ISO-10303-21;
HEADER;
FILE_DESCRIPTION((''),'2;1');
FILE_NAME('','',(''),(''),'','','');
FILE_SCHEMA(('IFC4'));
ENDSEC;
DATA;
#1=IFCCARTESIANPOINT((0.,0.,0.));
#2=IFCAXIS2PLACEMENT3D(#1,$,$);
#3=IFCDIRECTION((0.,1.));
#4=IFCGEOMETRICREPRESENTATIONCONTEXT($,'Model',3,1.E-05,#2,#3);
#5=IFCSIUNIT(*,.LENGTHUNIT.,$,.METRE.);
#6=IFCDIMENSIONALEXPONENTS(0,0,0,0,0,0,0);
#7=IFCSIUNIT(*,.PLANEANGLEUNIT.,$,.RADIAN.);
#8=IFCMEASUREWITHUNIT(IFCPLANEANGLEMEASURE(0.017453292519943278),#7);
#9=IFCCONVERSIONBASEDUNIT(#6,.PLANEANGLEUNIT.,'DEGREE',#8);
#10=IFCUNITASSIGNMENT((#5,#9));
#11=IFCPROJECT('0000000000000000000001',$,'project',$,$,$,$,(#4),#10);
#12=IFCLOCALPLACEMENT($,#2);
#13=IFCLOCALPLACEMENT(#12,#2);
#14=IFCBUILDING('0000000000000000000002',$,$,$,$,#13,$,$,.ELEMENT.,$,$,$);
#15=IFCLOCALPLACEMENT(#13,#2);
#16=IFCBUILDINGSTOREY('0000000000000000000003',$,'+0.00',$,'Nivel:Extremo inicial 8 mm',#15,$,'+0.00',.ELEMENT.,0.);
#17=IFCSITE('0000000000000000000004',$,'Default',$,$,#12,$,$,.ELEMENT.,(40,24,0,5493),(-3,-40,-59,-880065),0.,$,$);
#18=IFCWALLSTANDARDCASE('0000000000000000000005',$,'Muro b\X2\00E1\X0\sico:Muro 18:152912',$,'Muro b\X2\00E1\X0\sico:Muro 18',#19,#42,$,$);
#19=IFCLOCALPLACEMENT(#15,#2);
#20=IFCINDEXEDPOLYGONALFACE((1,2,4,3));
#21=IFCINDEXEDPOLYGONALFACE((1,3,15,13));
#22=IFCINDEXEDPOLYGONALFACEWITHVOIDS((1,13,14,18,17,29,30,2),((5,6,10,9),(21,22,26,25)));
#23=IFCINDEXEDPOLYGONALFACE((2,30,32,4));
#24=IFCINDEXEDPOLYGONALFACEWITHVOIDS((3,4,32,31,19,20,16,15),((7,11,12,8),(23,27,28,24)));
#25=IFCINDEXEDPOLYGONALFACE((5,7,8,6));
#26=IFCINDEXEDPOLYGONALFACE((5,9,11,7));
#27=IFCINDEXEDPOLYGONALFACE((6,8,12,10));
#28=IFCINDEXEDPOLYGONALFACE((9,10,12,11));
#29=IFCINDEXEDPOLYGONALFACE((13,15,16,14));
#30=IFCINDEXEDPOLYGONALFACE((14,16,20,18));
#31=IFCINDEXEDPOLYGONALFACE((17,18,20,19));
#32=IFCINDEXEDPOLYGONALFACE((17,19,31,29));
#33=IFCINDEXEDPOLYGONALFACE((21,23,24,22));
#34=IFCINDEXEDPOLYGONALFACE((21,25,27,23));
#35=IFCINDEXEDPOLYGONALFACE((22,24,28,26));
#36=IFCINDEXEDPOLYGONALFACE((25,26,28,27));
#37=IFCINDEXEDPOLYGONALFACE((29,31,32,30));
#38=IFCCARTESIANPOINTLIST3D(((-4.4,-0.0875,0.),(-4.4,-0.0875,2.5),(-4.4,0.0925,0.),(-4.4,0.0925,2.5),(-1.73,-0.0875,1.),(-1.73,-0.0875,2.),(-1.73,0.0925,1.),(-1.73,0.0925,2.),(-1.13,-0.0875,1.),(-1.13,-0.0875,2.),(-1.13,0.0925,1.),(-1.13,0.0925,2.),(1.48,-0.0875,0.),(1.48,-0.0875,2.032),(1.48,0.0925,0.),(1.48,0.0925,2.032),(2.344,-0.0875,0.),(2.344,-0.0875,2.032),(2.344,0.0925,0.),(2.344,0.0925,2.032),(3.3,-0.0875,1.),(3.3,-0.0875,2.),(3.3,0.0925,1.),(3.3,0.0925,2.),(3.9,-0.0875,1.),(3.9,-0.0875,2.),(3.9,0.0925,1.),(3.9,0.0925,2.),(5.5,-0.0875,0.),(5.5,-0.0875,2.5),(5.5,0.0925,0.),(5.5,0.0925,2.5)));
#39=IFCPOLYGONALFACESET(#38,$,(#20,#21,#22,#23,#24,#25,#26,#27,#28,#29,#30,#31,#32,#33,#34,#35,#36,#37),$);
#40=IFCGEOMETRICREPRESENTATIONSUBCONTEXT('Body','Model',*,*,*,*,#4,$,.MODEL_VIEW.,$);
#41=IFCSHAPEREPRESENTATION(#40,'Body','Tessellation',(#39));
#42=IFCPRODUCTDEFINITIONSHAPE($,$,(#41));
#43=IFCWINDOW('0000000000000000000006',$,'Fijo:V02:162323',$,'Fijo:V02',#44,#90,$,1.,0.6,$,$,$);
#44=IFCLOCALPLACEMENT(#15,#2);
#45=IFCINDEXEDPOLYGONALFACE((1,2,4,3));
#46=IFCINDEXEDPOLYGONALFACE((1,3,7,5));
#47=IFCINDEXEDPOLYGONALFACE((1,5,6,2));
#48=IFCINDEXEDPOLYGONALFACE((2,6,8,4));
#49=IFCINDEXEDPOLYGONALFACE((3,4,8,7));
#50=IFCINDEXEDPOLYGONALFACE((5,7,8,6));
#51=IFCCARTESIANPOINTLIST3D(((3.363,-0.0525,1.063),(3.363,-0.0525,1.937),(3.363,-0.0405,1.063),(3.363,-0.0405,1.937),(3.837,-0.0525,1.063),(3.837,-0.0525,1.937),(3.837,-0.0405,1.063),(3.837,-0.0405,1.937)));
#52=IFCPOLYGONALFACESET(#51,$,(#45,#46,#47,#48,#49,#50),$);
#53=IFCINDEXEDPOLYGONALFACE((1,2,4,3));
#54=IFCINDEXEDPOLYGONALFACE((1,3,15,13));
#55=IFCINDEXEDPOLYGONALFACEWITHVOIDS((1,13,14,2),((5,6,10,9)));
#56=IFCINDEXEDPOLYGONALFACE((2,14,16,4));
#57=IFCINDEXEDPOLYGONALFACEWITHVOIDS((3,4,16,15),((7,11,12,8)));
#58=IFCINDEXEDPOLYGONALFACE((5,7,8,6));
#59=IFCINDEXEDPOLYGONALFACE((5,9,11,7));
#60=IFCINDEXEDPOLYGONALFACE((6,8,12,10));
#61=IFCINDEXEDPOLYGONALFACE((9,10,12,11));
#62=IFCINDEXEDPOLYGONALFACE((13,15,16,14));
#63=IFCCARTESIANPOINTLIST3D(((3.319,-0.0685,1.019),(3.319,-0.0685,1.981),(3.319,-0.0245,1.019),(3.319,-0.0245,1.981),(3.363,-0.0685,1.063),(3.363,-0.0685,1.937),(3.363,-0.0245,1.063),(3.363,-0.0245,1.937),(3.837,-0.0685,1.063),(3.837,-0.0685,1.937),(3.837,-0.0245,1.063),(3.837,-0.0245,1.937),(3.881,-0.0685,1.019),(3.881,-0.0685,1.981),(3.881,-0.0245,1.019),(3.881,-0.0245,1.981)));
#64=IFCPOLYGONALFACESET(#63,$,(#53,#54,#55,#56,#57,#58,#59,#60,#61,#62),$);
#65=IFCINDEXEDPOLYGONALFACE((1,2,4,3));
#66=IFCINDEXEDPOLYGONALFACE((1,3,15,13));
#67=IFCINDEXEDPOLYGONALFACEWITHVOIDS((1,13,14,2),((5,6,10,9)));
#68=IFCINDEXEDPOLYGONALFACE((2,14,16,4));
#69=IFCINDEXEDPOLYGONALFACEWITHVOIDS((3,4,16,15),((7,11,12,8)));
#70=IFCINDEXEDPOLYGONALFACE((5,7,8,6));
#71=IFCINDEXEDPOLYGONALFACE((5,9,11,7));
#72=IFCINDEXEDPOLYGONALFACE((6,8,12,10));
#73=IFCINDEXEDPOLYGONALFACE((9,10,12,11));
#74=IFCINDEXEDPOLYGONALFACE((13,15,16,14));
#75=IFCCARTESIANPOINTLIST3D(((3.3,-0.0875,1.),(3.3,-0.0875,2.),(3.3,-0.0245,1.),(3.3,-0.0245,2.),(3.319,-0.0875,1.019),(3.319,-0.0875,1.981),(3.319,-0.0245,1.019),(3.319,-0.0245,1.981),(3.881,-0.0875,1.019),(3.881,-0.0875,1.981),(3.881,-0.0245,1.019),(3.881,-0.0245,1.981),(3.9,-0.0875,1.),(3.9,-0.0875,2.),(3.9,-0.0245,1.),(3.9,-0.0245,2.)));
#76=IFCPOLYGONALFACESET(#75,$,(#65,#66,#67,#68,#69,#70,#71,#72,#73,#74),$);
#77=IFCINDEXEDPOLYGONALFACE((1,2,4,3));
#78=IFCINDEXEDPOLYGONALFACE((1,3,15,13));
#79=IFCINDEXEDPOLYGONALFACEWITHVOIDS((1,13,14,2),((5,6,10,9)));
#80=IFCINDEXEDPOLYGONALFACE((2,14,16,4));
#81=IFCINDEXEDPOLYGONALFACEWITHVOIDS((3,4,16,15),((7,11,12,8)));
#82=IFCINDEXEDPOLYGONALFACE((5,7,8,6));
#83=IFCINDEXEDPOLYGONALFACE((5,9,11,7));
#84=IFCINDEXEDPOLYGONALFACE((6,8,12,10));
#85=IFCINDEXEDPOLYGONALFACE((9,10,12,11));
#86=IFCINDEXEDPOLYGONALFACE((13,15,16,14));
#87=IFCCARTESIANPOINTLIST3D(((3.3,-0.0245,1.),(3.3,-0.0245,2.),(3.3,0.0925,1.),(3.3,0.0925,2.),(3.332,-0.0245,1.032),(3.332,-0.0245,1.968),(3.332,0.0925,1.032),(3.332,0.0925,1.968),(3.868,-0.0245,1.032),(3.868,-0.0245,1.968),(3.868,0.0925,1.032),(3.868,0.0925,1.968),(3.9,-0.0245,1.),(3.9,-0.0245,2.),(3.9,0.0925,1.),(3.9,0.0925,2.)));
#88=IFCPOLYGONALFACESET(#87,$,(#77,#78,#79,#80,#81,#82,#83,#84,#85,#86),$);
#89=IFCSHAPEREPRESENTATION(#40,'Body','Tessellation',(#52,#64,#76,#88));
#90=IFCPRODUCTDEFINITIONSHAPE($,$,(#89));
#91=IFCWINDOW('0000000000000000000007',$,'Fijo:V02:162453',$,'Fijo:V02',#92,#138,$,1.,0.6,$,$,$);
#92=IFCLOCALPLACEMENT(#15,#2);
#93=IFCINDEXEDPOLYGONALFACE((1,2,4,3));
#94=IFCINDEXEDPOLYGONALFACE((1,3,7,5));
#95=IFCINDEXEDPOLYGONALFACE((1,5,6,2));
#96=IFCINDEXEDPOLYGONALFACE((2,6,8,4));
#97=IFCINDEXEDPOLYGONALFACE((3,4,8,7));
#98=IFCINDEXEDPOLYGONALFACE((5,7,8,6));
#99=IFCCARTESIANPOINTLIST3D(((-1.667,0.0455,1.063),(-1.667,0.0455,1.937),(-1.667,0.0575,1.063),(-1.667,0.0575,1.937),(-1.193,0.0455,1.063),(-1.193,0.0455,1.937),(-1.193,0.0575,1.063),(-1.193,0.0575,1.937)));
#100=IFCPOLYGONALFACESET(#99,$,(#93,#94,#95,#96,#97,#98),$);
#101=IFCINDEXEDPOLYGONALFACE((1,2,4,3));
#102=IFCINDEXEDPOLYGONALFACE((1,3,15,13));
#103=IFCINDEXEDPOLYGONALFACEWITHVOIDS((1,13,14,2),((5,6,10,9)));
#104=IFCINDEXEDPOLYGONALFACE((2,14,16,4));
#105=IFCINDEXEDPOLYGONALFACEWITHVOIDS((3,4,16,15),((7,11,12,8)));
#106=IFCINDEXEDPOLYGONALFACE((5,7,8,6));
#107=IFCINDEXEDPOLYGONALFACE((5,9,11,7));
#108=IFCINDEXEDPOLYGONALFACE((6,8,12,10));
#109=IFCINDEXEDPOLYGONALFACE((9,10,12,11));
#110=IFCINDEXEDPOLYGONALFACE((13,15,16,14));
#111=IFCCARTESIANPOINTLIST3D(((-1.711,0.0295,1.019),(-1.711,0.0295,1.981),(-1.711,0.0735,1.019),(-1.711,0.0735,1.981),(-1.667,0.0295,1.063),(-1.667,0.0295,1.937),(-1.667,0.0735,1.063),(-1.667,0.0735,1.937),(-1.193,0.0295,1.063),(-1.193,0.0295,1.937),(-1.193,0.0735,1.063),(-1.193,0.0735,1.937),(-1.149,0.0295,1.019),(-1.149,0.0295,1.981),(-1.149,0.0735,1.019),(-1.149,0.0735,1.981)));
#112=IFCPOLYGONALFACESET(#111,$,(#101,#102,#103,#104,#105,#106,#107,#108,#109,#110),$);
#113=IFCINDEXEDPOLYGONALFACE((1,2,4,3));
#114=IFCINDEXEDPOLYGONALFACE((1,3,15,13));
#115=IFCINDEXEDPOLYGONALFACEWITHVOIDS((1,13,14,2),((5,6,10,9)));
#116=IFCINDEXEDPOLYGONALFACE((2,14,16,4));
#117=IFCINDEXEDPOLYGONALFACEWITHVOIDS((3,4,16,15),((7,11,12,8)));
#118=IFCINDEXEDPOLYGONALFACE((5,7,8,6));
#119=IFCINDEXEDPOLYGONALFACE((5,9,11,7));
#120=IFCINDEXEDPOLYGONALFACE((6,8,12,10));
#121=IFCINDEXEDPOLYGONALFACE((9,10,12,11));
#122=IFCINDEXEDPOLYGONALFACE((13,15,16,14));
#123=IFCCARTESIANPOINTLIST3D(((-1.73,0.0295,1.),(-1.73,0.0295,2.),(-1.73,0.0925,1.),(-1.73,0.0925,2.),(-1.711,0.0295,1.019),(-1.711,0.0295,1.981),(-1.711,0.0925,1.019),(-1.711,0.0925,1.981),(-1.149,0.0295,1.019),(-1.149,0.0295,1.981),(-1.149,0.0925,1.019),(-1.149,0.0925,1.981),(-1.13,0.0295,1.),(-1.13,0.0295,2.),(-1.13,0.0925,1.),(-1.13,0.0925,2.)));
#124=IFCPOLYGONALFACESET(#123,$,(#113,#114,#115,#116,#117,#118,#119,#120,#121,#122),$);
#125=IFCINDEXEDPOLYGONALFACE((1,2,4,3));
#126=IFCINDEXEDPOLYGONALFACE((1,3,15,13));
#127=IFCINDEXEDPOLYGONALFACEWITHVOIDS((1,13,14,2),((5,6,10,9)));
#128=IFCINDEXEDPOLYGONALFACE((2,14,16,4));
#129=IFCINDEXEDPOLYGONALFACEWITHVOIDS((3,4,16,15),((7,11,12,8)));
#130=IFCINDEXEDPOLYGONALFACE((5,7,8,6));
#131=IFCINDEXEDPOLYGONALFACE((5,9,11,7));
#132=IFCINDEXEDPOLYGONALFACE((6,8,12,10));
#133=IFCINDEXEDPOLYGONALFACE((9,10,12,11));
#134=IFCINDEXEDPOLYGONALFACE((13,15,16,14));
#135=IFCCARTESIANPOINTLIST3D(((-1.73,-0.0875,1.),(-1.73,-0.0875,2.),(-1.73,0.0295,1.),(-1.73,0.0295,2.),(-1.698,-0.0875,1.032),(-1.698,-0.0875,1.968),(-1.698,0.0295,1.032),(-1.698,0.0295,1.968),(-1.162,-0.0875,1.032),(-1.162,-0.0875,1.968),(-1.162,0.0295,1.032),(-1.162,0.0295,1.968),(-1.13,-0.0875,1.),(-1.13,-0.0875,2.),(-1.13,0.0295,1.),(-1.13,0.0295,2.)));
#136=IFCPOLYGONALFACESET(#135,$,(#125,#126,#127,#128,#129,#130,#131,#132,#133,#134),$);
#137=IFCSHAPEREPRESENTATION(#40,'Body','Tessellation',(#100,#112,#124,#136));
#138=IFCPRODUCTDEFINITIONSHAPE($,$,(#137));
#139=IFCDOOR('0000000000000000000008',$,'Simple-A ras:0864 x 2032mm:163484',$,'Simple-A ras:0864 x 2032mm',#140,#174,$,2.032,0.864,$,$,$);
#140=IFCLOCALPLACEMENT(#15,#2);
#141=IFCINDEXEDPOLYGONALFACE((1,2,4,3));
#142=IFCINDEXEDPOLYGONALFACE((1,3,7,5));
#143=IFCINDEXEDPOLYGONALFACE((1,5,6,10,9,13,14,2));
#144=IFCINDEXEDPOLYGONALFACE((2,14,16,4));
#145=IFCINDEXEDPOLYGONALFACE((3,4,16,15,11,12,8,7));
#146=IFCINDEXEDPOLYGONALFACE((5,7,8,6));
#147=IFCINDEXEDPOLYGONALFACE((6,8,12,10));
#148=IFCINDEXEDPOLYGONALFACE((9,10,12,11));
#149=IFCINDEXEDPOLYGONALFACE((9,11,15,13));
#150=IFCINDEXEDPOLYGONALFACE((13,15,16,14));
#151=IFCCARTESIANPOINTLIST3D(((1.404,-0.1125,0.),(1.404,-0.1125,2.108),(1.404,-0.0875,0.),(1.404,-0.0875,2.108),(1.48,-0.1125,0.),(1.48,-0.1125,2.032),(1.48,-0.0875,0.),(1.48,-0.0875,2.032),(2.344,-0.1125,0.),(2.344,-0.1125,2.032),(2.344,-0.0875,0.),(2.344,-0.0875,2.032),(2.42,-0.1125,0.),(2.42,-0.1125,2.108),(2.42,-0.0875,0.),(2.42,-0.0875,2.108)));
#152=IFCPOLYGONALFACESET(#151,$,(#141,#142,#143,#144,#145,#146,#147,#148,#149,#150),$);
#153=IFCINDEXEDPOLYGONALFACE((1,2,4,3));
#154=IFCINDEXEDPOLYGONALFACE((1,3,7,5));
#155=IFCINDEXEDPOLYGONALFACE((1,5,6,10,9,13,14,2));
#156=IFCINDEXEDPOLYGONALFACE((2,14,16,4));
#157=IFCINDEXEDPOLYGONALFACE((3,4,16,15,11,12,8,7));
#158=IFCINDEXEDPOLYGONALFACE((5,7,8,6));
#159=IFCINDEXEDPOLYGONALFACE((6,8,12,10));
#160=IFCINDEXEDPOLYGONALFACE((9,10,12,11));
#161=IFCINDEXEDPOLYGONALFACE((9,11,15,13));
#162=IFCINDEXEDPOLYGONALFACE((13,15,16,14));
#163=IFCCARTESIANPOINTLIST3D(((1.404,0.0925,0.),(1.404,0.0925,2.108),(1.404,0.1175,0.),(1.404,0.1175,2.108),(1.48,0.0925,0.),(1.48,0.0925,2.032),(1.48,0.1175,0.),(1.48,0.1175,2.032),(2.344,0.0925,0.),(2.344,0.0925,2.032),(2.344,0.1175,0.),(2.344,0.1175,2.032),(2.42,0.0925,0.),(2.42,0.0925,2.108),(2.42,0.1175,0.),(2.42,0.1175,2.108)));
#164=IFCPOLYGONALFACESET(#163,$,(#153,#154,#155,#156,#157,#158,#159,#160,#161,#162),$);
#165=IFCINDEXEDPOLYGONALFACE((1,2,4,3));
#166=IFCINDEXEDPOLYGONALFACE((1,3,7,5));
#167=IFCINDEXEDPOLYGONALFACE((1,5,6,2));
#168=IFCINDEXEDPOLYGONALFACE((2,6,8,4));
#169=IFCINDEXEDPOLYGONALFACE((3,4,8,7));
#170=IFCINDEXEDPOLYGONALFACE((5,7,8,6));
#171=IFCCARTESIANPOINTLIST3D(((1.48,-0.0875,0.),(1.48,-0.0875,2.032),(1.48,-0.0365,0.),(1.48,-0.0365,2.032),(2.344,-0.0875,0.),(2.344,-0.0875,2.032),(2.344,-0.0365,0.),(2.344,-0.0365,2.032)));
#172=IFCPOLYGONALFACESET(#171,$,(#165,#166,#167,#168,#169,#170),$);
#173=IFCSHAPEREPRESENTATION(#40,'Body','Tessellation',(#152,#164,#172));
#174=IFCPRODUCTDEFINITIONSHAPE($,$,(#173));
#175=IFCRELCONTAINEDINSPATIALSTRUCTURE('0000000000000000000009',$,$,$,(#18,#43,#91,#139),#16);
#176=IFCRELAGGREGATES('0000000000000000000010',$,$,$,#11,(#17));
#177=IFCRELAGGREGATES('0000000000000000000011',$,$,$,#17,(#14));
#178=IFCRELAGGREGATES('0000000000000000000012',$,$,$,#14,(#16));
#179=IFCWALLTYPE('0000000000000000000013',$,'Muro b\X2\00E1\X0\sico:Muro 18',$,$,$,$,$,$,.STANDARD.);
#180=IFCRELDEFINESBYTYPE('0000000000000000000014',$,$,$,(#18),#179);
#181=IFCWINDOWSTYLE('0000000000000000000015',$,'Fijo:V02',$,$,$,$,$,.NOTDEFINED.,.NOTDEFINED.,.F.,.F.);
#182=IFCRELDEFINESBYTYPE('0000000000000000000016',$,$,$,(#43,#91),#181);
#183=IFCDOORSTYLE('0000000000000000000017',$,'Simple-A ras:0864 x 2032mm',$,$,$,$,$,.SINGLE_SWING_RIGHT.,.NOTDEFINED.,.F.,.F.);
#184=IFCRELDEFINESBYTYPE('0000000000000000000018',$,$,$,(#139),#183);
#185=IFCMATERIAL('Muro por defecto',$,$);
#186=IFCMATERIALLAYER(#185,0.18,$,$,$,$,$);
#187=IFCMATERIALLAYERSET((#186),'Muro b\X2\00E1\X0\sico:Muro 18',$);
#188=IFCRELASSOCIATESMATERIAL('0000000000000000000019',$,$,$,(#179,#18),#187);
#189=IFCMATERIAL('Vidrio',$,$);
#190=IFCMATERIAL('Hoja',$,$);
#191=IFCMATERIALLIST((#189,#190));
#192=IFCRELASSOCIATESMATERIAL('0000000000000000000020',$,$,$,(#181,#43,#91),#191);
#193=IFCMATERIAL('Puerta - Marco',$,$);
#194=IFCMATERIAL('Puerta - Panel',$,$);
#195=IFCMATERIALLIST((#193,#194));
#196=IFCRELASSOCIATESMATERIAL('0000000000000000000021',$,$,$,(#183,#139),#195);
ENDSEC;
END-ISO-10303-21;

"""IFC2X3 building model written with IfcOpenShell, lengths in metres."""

from ifc_helpers import new_model, entity, si_unit, converted_unit, direction, frame, frame_2d, origin, place, context, subcontext, project, spatial, polyline, rectangle, outline, extrude, source, transform, mapped, material, material_list, layer, layer_set, layer_usage, type_object, type_shapes, element, fill, save


model = new_model("IFC2X3")

# Units and contexts
model_context = context("Model", 3, precision=1e-05, world=origin(), true_north=direction((0.0, 1.0)))
body_context = subcontext(model_context, "Body", "Model", "MODEL_VIEW")
ifc_project = project(units=[si_unit("LENGTHUNIT", "METRE"), converted_unit("PLANEANGLEUNIT", "DEGREE", entity("IfcPlaneAngleMeasure", 0.017453292519943278), si_unit("PLANEANGLEUNIT", "RADIAN"), dimensions=[0, 0, 0, 0, 0, 0, 0])], contexts=[model_context])

# Site, building, storey
site_placement = place(None, origin())
site = spatial("IfcSite", under=ifc_project, at=site_placement, Name="Default", CompositionType="ELEMENT", RefLatitude=(40, 24, 0, 5493), RefLongitude=(-3, -40, -59, -880065), RefElevation=0.0)
building_placement = place(site_placement, origin())
building = spatial("IfcBuilding", under=site, at=building_placement, CompositionType="ELEMENT")
storey_placement = place(building_placement, origin())
storey = spatial("IfcBuildingStorey", under=building, at=storey_placement, Name="+0.00", ObjectType="Nivel:Extremo inicial 8 mm", LongName="+0.00", CompositionType="ELEMENT", Elevation=0.0)

# Shared definitions
ifc_material_1 = material(Name="Muro por defecto")
ifc_layer = layer(ifc_material_1, 0.18)
ifc_layer_set = layer_set([ifc_layer], Name="Muro básico:Muro 18")
wall_type = type_object("IfcWallType", Name="Muro básico:Muro 18", PredefinedType="STANDARD", material=ifc_layer_set)
ifc_material_2 = material(Name="Vidrio")
ifc_material_3 = material(Name="Hoja")
ifc_material_list_1 = material_list([ifc_material_2, ifc_material_3])
window_style_1 = type_object("IfcWindowStyle", Name="Fijo:V02", ConstructionType="NOTDEFINED", OperationType="NOTDEFINED", ParameterTakesPrecedence=False, Sizeable=False, material=ifc_material_list_1)
shared_shape_1 = source(origin(), body_context, "Body", "SweptSolid", [
    extrude(rectangle(XDim=0.012, YDim=0.474, at=frame_2d((0.0, 0.0), x_axis=(1.0, 0.0))), frame((0.3, 0.139, 0.063), z_axis=(0.0, 0.0, 1.0), x_axis=(0.0, -1.0, 0.0)), (0.0, 0.0, 1.0), 0.874),
    extrude(outline(polyline([(-0.281, -0.481), (0.281, -0.481), (0.281, 0.481), (-0.281, 0.481), (-0.281, -0.481)]), holes=[polyline([(-0.237, -0.437), (-0.237, 0.437), (0.237, 0.437), (0.237, -0.437), (-0.237, -0.437)])]), frame((0.3, 0.117, 0.5), z_axis=(0.0, 1.0, 0.0), x_axis=(1.0, 0.0, 0.0)), (0.0, 0.0, 1.0), 0.044),
    extrude(outline(polyline([(-0.3, -0.5), (0.3, -0.5), (0.3, 0.5), (-0.3, 0.5), (-0.3, -0.5)]), holes=[polyline([(-0.281, -0.481), (-0.281, 0.481), (0.281, 0.481), (0.281, -0.481), (-0.281, -0.481)])]), frame((0.3, 0.117, 0.5), z_axis=(0.0, 1.0, 0.0), x_axis=(1.0, 0.0, 0.0)), (0.0, 0.0, 1.0), 0.063),
    extrude(outline(polyline([(-0.3, -0.5), (0.3, -0.5), (0.3, 0.5), (-0.3, 0.5), (-0.3, -0.5)]), holes=[polyline([(-0.268, -0.468), (-0.268, 0.468), (0.268, 0.468), (0.268, -0.468), (-0.268, -0.468)])]), frame((0.3, 0.0, 0.5), z_axis=(0.0, 1.0, 0.0), x_axis=(1.0, 0.0, 0.0)), (0.0, 0.0, 1.0), 0.117),
])
type_shapes(window_style_1, [shared_shape_1])

# Wall, openings, windows, door
ifc_layer_usage_1 = layer_usage(ifc_layer_set, "AXIS2", "POSITIVE", -0.09)
wall_1_placement = place(storey_placement, frame((5.5, 0.0025, 0.0), z_axis=(0.0, 0.0, 1.0), x_axis=(-1.0, 0.0, 0.0)))
wall_1 = element("IfcWallStandardCase", 1, at=wall_1_placement, inside=storey, type_object=wall_type, material=ifc_layer_usage_1, Name="Muro básico:Muro 18:152912", ObjectType="Muro básico:Muro 18", context=body_context, shape_type="SweptSolid", body=[
    extrude(rectangle(XDim=9.9, YDim=0.18, at=frame_2d((4.95, 0.0), x_axis=(1.0, 0.0))), origin(), (0.0, 0.0, 1.0), 2.5),
])
opening_1_placement = place(wall_1_placement, frame((3.156, -0.09, 0.0)))
opening_1 = element("IfcOpeningElement", 2, at=opening_1_placement, cuts=wall_1, ObjectType="Opening", context=body_context, shape_type="SweptSolid", body=[
    extrude(rectangle(XDim=0.864, YDim=2.032, at=frame_2d((1.016, 0.432), x_axis=(0.0, 1.0))), frame((0.0, 0.0, 0.0), z_axis=(0.0, 1.0, 0.0), x_axis=(0.0, 0.0, 1.0)), (0.0, 0.0, 1.0), 0.18),
])
opening_2_placement = place(wall_1_placement, frame((1.6, -0.09, 1.0)))
opening_2 = element("IfcOpeningElement", 3, at=opening_2_placement, cuts=wall_1, ObjectType="Opening", context=body_context, shape_type="SweptSolid", body=[
    extrude(rectangle(XDim=1.0, YDim=0.6, at=frame_2d((0.5, 0.3), x_axis=(1.0, 0.0))), frame((0.0, 0.0, 0.0), z_axis=(0.0, 1.0, 0.0), x_axis=(0.0, 0.0, 1.0)), (0.0, 0.0, 1.0), 0.18),
])
opening_3_placement = place(wall_1_placement, frame((7.23, 0.09, 1.0)))
opening_3 = element("IfcOpeningElement", 4, at=opening_3_placement, cuts=wall_1, ObjectType="Opening", context=body_context, shape_type="SweptSolid", body=[
    extrude(rectangle(XDim=1.0, YDim=0.6, at=frame_2d((0.5, 0.3), x_axis=(1.0, 0.0))), frame((0.0, 0.0, 0.0), z_axis=(0.0, -1.0, 0.0), x_axis=(0.0, 0.0, 1.0)), (0.0, 0.0, 1.0), 0.18),
])
window_1_placement = place(opening_2_placement, origin())
window_1 = element("IfcWindow", 5, at=window_1_placement, inside=storey, type_object=window_style_1, material=ifc_material_list_1, Name="Fijo:V02:162323", ObjectType="Fijo:V02", OverallHeight=1.0, OverallWidth=0.6, context=body_context, shape_type="MappedRepresentation", body=[
    mapped(shared_shape_1, transform((0.0, 0.0, 0.0), scale=1.0)),
])
fill(opening_2, window_1)
window_2_placement = place(opening_3_placement, frame((0.0, 0.0, 0.0), z_axis=(0.0, 0.0, 1.0), x_axis=(-1.0, 0.0, 0.0)))
window_2 = element("IfcWindow", 6, at=window_2_placement, inside=storey, type_object=window_style_1, material=ifc_material_list_1, Name="Fijo:V02:162453", ObjectType="Fijo:V02", OverallHeight=1.0, OverallWidth=0.6, context=body_context, shape_type="MappedRepresentation", body=[
    mapped(shared_shape_1, transform((0.0, 0.0, 0.0), scale=1.0)),
])
fill(opening_3, window_2)
ifc_material_4 = material(Name="Puerta - Marco")
ifc_material_5 = material(Name="Puerta - Panel")
ifc_material_list_2 = material_list([ifc_material_4, ifc_material_5])
door_style_1 = type_object("IfcDoorStyle", Name="Simple-A ras:0864 x 2032mm", ConstructionType="NOTDEFINED", OperationType="SINGLE_SWING_RIGHT", ParameterTakesPrecedence=False, Sizeable=False, material=ifc_material_list_2)
shared_shape_2 = source(origin(), body_context, "Body", "SweptSolid", [
    extrude(outline(polyline([(-0.508, -1.073), (0.508, -1.073), (0.508, 1.035), (0.432, 1.035), (0.432, -0.997), (-0.432, -0.997), (-0.432, 1.035), (-0.508, 1.035), (-0.508, -1.073)])), frame((0.432, 0.18, 1.035), z_axis=(0.0, 1.0, 0.0), x_axis=(1.0, 0.0, 0.0)), (0.0, 0.0, 1.0), 0.025),
    extrude(outline(polyline([(-1.073, -0.508), (1.035, -0.508), (1.035, -0.432), (-0.997, -0.432), (-0.997, 0.432), (1.035, 0.432), (1.035, 0.508), (-1.073, 0.508), (-1.073, -0.508)])), frame((0.432, -0.025, 1.035), z_axis=(0.0, 1.0, 0.0), x_axis=(0.0, 0.0, -1.0)), (0.0, 0.0, 1.0), 0.025),
    extrude(rectangle(XDim=0.051, YDim=0.864, at=frame_2d((0.0, 0.0), x_axis=(1.0, 0.0))), frame((0.432, 0.1545, 0.0), z_axis=(0.0, 0.0, 1.0), x_axis=(0.0, 1.0, 0.0)), (0.0, 0.0, 1.0), 2.032),
])
type_shapes(door_style_1, [shared_shape_2])
door_1_placement = place(opening_1_placement, origin())
door_1 = element("IfcDoor", 7, at=door_1_placement, inside=storey, type_object=door_style_1, material=ifc_material_list_2, Name="Simple-A ras:0864 x 2032mm:163484", ObjectType="Simple-A ras:0864 x 2032mm", OverallHeight=2.032, OverallWidth=0.864, context=body_context, shape_type="MappedRepresentation", body=[
    mapped(shared_shape_2, transform((0.0, 0.0, 0.0), scale=1.0)),
])
fill(opening_1, door_1)

save(model, "model.ifc")
